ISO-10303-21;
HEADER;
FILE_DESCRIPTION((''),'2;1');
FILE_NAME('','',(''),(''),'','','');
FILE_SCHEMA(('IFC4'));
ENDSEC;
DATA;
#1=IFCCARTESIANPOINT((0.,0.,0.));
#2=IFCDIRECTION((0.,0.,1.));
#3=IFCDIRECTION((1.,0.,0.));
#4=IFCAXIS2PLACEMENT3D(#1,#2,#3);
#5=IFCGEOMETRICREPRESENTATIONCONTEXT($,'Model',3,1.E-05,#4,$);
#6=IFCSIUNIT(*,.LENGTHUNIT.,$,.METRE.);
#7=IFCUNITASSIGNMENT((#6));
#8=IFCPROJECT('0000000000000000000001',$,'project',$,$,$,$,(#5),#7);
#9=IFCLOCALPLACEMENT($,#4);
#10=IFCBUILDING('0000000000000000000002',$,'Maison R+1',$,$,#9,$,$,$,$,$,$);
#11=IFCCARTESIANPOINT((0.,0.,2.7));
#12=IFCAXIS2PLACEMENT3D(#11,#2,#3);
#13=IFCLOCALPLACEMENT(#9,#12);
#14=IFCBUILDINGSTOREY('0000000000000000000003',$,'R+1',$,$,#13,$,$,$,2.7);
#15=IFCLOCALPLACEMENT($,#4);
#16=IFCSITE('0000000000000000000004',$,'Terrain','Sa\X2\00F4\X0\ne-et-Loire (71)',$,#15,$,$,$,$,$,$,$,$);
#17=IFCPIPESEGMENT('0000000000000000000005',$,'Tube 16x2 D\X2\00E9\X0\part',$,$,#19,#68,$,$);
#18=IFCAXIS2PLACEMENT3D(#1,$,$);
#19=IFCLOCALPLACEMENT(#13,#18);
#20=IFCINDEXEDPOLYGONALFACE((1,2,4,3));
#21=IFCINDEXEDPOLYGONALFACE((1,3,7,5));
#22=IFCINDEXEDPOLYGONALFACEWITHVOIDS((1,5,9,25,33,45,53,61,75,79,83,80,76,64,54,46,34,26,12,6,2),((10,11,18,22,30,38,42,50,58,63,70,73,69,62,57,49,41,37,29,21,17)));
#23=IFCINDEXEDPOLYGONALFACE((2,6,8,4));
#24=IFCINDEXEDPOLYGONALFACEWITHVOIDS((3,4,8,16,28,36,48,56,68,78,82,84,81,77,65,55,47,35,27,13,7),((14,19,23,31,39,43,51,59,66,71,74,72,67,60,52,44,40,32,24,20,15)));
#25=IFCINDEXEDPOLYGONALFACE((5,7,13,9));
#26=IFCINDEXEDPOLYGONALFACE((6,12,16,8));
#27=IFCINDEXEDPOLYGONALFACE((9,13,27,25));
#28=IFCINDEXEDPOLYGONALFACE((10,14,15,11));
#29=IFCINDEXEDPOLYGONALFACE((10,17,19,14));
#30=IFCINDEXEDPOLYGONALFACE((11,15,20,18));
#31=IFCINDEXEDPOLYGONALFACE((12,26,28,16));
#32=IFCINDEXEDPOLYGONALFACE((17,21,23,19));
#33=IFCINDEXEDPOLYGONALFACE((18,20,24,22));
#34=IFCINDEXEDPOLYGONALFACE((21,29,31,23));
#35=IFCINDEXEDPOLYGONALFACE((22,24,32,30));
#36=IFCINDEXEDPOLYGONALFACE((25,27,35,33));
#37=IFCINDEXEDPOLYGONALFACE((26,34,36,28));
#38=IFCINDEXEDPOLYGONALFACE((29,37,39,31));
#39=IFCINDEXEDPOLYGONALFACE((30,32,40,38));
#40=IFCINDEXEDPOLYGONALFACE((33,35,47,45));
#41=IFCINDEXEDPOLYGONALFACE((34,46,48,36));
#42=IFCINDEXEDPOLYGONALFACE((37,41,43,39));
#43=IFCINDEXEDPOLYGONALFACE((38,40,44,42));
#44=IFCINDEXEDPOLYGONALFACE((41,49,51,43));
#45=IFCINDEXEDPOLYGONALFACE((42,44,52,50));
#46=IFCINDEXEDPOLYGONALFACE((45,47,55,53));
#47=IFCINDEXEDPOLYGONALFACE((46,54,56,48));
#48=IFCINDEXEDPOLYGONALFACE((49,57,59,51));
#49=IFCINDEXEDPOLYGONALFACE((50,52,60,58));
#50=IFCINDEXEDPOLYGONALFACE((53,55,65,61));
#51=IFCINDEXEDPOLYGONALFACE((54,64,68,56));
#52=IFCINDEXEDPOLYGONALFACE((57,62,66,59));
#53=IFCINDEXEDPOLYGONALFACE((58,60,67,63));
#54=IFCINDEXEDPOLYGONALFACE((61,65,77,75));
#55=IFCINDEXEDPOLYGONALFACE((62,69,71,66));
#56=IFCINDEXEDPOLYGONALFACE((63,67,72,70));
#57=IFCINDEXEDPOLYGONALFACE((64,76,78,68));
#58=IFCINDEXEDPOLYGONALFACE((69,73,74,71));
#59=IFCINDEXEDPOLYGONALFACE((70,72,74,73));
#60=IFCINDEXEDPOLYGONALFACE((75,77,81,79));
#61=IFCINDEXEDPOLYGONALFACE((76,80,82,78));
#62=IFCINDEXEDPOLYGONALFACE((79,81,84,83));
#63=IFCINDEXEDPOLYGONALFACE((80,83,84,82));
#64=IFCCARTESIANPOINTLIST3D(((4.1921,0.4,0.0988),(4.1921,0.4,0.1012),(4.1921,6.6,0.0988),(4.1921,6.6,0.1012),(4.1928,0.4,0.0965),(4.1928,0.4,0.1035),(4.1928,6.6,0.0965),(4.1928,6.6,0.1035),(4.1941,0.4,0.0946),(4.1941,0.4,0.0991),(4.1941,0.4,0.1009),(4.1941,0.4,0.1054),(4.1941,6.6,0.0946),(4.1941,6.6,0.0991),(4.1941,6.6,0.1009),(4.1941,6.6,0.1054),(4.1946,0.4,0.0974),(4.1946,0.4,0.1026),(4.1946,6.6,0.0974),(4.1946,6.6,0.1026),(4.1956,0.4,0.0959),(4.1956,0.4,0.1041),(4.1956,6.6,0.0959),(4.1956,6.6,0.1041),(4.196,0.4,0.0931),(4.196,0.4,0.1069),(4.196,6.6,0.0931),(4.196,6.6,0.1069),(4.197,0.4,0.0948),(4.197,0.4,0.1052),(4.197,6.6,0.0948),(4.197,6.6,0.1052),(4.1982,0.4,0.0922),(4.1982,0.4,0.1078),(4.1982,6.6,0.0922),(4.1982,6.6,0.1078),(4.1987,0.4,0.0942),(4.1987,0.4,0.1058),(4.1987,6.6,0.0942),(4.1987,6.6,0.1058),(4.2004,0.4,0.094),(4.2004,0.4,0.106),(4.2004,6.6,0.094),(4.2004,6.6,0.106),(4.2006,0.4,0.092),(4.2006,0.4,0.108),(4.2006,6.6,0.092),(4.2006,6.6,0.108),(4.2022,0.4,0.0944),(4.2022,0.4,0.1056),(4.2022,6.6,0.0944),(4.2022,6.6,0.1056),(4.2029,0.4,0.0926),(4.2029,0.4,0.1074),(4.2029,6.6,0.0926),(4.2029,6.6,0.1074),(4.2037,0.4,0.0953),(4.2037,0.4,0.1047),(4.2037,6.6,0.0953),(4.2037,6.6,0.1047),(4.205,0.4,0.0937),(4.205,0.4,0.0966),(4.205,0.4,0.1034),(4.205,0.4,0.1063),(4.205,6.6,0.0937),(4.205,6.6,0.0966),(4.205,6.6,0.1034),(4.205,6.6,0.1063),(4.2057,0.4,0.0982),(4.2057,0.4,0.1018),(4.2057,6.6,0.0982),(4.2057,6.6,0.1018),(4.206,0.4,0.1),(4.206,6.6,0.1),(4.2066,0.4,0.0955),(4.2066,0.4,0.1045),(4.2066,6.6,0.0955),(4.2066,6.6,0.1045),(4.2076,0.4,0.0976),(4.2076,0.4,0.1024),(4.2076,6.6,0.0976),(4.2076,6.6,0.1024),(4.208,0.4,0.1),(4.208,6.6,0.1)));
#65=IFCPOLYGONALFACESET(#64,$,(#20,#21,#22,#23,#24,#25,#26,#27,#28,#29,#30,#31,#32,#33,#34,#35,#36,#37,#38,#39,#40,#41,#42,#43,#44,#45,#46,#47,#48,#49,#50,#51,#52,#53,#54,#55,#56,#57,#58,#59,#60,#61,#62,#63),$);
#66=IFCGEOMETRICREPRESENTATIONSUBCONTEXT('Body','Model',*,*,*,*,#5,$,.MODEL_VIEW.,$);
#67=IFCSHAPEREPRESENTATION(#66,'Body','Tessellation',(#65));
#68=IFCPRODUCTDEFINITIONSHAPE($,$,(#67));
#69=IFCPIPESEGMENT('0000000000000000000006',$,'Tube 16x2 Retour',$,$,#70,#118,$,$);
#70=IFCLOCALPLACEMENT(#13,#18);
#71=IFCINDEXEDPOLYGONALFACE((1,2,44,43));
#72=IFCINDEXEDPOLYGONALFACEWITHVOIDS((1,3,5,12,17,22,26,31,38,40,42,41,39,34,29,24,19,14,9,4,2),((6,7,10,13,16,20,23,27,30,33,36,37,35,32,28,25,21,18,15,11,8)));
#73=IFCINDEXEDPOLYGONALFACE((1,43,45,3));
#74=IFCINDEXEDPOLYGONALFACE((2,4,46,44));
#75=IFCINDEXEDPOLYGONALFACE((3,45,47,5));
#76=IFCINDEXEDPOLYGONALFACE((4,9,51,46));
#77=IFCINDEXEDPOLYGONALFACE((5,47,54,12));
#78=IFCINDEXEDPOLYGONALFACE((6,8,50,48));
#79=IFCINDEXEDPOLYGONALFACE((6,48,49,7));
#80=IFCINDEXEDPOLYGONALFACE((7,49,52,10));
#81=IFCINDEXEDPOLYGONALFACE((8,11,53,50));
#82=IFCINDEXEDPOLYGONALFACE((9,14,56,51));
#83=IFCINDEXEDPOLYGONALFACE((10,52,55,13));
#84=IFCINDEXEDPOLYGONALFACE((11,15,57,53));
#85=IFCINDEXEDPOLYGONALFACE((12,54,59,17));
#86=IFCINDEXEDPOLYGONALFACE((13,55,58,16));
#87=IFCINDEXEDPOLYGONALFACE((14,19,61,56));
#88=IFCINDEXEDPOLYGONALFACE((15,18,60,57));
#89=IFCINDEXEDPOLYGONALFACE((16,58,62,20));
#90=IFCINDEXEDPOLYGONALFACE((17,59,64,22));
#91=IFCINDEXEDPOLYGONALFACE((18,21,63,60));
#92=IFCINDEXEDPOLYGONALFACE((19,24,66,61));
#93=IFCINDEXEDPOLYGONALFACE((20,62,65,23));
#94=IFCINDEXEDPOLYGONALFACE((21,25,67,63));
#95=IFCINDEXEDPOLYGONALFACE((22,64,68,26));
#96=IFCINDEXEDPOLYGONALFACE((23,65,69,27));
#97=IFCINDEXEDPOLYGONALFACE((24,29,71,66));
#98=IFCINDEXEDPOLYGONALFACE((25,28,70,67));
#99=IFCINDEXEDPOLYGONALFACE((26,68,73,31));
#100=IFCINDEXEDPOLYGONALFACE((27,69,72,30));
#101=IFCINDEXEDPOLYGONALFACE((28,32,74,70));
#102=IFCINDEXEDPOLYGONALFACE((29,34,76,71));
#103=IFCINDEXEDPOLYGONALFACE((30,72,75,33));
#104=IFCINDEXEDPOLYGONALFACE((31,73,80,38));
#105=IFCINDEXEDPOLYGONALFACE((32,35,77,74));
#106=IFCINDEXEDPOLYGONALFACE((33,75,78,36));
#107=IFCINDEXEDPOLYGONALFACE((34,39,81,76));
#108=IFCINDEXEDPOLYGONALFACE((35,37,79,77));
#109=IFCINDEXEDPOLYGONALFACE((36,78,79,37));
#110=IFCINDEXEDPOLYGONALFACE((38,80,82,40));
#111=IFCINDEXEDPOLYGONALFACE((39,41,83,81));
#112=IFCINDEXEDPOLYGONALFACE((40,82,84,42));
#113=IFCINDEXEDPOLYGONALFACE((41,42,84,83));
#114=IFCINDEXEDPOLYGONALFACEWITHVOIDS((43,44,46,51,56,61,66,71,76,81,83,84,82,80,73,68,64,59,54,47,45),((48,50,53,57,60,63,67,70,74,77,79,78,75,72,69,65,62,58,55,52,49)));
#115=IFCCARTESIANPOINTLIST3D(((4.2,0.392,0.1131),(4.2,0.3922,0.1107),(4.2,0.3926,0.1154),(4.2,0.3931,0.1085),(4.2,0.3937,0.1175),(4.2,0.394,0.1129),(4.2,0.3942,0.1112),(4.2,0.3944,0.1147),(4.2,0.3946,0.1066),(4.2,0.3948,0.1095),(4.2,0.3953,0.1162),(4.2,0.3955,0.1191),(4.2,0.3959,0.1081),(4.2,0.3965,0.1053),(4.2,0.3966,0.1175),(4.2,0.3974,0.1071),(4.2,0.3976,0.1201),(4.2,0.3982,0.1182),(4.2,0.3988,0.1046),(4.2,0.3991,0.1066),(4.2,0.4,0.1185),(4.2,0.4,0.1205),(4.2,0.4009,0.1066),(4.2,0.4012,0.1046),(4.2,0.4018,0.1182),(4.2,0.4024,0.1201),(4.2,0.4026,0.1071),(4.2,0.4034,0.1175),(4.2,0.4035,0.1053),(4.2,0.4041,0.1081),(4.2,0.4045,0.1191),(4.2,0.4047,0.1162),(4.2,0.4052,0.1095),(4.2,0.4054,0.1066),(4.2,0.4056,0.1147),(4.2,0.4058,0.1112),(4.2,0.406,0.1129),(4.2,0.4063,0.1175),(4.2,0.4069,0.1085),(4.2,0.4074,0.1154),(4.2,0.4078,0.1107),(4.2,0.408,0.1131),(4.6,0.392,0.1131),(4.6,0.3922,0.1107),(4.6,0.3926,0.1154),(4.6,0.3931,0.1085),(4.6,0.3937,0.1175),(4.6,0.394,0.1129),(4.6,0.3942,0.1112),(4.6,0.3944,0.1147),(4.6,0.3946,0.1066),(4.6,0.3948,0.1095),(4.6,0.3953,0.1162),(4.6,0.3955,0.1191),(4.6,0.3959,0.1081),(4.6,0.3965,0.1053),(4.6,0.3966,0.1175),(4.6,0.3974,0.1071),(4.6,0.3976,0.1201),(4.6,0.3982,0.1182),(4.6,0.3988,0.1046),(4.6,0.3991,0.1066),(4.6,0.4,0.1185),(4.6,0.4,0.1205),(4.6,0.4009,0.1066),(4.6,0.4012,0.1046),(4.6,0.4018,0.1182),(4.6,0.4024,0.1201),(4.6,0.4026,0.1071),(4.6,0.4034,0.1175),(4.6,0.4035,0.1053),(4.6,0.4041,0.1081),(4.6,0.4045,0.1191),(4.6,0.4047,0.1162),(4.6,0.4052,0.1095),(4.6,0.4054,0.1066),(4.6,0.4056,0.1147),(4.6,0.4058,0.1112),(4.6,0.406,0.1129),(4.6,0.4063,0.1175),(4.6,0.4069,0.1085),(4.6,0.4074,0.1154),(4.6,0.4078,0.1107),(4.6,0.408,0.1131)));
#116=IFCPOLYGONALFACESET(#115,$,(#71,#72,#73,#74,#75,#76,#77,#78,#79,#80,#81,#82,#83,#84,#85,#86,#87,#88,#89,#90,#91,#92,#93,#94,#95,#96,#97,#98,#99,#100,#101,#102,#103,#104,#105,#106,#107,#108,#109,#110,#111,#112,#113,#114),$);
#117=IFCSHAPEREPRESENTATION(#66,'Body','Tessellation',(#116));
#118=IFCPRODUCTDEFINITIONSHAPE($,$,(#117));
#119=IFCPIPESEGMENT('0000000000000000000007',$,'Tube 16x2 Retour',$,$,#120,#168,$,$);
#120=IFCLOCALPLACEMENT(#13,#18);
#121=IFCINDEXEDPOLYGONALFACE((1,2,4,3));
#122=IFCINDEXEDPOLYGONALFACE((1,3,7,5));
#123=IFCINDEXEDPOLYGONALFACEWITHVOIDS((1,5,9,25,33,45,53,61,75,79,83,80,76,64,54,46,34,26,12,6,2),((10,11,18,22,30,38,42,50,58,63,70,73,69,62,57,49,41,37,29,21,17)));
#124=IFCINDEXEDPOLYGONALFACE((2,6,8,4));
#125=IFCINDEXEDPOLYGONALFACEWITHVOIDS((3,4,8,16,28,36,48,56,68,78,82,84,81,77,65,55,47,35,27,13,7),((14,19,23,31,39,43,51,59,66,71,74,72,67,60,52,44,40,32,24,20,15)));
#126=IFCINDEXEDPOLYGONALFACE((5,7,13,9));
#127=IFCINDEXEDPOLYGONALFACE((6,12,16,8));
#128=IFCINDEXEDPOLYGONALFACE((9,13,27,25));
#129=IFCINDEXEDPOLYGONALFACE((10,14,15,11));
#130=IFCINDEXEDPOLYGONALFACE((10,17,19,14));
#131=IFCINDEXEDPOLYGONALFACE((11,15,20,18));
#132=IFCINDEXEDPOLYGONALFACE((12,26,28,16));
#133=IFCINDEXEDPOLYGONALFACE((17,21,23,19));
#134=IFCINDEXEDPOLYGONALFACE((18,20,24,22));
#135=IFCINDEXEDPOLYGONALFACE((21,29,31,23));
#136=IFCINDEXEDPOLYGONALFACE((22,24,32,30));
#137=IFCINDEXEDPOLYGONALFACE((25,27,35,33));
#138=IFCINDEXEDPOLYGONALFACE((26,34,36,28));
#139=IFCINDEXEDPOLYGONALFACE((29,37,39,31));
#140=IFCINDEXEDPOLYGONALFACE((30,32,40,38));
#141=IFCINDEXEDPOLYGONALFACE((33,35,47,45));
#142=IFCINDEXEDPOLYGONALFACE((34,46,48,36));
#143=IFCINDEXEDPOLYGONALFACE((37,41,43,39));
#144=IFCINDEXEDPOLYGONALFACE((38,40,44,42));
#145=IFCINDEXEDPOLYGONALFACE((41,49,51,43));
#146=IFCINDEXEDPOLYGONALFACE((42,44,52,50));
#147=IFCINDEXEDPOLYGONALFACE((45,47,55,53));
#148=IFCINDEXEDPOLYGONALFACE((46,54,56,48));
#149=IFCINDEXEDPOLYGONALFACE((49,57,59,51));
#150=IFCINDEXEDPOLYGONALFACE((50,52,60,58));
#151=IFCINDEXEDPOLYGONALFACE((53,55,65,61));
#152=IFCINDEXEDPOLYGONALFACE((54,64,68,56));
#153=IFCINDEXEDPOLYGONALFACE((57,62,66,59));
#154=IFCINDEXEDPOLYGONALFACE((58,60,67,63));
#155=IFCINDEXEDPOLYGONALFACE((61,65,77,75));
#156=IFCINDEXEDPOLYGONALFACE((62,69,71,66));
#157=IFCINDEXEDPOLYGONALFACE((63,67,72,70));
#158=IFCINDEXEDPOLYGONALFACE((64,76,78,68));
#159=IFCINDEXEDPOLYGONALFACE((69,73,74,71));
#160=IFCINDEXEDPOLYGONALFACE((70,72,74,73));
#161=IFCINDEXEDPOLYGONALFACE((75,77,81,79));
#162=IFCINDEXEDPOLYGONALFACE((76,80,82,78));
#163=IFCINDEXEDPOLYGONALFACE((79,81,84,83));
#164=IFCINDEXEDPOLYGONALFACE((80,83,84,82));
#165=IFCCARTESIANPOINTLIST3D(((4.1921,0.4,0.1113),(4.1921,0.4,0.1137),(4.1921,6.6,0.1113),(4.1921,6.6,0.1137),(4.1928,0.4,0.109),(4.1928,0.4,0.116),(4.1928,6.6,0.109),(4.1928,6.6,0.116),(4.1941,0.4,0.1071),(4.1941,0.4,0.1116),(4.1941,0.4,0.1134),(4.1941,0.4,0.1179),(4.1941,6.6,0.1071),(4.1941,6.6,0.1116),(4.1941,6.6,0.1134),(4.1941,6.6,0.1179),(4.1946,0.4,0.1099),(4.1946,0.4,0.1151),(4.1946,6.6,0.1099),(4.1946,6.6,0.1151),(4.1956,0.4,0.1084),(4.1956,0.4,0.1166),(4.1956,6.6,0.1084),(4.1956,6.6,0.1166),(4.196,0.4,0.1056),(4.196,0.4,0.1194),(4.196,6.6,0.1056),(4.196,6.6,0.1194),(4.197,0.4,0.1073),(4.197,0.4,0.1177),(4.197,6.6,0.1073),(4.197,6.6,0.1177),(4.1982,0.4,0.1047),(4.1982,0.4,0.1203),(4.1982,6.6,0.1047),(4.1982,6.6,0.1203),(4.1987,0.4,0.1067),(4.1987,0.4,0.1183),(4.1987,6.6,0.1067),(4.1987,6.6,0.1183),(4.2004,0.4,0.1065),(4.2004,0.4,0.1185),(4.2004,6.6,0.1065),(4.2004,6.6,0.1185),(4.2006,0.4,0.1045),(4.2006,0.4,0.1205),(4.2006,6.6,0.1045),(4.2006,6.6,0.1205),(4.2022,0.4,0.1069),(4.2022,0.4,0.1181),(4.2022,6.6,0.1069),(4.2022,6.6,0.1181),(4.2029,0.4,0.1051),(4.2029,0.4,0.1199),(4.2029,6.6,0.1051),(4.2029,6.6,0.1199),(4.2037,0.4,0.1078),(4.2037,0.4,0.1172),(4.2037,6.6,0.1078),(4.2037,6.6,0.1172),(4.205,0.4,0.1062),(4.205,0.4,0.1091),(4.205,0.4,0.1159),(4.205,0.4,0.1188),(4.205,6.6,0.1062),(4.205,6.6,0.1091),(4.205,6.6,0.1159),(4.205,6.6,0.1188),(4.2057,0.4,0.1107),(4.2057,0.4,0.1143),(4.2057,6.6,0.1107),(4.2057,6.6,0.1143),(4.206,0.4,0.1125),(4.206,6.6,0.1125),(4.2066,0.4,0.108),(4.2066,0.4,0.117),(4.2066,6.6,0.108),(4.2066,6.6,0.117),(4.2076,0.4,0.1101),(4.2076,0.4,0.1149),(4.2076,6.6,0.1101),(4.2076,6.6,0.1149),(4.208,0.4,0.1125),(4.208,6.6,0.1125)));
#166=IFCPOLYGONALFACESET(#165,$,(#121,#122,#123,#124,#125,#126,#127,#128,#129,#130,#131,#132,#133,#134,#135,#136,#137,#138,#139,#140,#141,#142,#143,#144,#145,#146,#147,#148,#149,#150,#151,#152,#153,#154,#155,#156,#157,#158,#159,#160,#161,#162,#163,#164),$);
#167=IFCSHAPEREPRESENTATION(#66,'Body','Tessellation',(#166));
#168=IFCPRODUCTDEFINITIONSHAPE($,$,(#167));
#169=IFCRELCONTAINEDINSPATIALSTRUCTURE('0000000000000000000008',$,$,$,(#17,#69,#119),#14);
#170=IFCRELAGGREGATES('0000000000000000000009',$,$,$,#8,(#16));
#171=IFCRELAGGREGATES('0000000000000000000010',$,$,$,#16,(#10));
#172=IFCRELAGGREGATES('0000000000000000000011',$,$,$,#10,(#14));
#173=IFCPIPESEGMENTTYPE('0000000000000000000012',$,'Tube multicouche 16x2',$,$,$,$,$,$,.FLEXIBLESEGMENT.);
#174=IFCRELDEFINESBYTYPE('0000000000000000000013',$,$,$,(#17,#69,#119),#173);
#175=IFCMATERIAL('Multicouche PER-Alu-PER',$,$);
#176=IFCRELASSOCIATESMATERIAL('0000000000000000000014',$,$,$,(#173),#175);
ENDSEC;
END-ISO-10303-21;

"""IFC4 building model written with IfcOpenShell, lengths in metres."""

from ifc_helpers import new_model, si_unit, frame, origin_with_axes, place, context, subcontext, project, spatial, hollow_circle, extrude, material, type_object, element, save


model = new_model("IFC4")

# Units and contexts
model_context = context("Model", 3, precision=1e-05, world=origin_with_axes())
body_context = subcontext(model_context, "Body", "Model", "MODEL_VIEW")
ifc_project = project(units=[si_unit("LENGTHUNIT", "METRE")], contexts=[model_context])

# Site, building, storey
site_placement = place(None, origin_with_axes())
site = spatial("IfcSite", under=ifc_project, at=site_placement, Name="Terrain", Description="Saône-et-Loire (71)")
building_placement = place(None, origin_with_axes())
building = spatial("IfcBuilding", under=site, at=building_placement, Name="Maison R+1")
storey_placement = place(building_placement, frame((0.0, 0.0, 2.7), z_axis=(0.0, 0.0, 1.0), x_axis=(1.0, 0.0, 0.0)))
storey = spatial("IfcBuildingStorey", under=building, at=storey_placement, Name="R+1", Elevation=2.7)

# Pipe segments
ifc_material_1 = material(Name="Multicouche PER-Alu-PER")
pipe_segment_type = type_object("IfcPipeSegmentType", Name="Tube multicouche 16x2", PredefinedType="FLEXIBLESEGMENT", material=ifc_material_1)
pipe_segment_1_placement = place(storey_placement, frame((4.2, 0.4, 0.1), z_axis=(0.0, 1.0, 0.0), x_axis=(1.0, 0.0, 0.0)))
element("IfcPipeSegment", 1, at=pipe_segment_1_placement, inside=storey, type_object=pipe_segment_type, Name="Tube 16x2 Départ", context=body_context, shape_type="SweptSolid", body=[
    extrude(hollow_circle(Radius=0.008, WallThickness=0.002), origin_with_axes(), (0.0, 0.0, 1.0), 6.2),
])
pipe_segment_2_placement = place(storey_placement, frame((4.6, 0.4, 0.1125), z_axis=(-1.0, 0.0, 0.0), x_axis=(0.0, 0.0, 1.0)))
element("IfcPipeSegment", 2, at=pipe_segment_2_placement, inside=storey, type_object=pipe_segment_type, Name="Tube 16x2 Retour", context=body_context, shape_type="SweptSolid", body=[
    extrude(hollow_circle(Radius=0.008, WallThickness=0.002), origin_with_axes(), (0.0, 0.0, 1.0), 0.4),
])
pipe_segment_3_placement = place(storey_placement, frame((4.2, 0.4, 0.1125), z_axis=(0.0, 1.0, 0.0), x_axis=(1.0, 0.0, 0.0)))
element("IfcPipeSegment", 3, at=pipe_segment_3_placement, inside=storey, type_object=pipe_segment_type, Name="Tube 16x2 Retour", context=body_context, shape_type="SweptSolid", body=[
    extrude(hollow_circle(Radius=0.008, WallThickness=0.002), origin_with_axes(), (0.0, 0.0, 1.0), 6.2),
])

save(model, "model.ifc")
